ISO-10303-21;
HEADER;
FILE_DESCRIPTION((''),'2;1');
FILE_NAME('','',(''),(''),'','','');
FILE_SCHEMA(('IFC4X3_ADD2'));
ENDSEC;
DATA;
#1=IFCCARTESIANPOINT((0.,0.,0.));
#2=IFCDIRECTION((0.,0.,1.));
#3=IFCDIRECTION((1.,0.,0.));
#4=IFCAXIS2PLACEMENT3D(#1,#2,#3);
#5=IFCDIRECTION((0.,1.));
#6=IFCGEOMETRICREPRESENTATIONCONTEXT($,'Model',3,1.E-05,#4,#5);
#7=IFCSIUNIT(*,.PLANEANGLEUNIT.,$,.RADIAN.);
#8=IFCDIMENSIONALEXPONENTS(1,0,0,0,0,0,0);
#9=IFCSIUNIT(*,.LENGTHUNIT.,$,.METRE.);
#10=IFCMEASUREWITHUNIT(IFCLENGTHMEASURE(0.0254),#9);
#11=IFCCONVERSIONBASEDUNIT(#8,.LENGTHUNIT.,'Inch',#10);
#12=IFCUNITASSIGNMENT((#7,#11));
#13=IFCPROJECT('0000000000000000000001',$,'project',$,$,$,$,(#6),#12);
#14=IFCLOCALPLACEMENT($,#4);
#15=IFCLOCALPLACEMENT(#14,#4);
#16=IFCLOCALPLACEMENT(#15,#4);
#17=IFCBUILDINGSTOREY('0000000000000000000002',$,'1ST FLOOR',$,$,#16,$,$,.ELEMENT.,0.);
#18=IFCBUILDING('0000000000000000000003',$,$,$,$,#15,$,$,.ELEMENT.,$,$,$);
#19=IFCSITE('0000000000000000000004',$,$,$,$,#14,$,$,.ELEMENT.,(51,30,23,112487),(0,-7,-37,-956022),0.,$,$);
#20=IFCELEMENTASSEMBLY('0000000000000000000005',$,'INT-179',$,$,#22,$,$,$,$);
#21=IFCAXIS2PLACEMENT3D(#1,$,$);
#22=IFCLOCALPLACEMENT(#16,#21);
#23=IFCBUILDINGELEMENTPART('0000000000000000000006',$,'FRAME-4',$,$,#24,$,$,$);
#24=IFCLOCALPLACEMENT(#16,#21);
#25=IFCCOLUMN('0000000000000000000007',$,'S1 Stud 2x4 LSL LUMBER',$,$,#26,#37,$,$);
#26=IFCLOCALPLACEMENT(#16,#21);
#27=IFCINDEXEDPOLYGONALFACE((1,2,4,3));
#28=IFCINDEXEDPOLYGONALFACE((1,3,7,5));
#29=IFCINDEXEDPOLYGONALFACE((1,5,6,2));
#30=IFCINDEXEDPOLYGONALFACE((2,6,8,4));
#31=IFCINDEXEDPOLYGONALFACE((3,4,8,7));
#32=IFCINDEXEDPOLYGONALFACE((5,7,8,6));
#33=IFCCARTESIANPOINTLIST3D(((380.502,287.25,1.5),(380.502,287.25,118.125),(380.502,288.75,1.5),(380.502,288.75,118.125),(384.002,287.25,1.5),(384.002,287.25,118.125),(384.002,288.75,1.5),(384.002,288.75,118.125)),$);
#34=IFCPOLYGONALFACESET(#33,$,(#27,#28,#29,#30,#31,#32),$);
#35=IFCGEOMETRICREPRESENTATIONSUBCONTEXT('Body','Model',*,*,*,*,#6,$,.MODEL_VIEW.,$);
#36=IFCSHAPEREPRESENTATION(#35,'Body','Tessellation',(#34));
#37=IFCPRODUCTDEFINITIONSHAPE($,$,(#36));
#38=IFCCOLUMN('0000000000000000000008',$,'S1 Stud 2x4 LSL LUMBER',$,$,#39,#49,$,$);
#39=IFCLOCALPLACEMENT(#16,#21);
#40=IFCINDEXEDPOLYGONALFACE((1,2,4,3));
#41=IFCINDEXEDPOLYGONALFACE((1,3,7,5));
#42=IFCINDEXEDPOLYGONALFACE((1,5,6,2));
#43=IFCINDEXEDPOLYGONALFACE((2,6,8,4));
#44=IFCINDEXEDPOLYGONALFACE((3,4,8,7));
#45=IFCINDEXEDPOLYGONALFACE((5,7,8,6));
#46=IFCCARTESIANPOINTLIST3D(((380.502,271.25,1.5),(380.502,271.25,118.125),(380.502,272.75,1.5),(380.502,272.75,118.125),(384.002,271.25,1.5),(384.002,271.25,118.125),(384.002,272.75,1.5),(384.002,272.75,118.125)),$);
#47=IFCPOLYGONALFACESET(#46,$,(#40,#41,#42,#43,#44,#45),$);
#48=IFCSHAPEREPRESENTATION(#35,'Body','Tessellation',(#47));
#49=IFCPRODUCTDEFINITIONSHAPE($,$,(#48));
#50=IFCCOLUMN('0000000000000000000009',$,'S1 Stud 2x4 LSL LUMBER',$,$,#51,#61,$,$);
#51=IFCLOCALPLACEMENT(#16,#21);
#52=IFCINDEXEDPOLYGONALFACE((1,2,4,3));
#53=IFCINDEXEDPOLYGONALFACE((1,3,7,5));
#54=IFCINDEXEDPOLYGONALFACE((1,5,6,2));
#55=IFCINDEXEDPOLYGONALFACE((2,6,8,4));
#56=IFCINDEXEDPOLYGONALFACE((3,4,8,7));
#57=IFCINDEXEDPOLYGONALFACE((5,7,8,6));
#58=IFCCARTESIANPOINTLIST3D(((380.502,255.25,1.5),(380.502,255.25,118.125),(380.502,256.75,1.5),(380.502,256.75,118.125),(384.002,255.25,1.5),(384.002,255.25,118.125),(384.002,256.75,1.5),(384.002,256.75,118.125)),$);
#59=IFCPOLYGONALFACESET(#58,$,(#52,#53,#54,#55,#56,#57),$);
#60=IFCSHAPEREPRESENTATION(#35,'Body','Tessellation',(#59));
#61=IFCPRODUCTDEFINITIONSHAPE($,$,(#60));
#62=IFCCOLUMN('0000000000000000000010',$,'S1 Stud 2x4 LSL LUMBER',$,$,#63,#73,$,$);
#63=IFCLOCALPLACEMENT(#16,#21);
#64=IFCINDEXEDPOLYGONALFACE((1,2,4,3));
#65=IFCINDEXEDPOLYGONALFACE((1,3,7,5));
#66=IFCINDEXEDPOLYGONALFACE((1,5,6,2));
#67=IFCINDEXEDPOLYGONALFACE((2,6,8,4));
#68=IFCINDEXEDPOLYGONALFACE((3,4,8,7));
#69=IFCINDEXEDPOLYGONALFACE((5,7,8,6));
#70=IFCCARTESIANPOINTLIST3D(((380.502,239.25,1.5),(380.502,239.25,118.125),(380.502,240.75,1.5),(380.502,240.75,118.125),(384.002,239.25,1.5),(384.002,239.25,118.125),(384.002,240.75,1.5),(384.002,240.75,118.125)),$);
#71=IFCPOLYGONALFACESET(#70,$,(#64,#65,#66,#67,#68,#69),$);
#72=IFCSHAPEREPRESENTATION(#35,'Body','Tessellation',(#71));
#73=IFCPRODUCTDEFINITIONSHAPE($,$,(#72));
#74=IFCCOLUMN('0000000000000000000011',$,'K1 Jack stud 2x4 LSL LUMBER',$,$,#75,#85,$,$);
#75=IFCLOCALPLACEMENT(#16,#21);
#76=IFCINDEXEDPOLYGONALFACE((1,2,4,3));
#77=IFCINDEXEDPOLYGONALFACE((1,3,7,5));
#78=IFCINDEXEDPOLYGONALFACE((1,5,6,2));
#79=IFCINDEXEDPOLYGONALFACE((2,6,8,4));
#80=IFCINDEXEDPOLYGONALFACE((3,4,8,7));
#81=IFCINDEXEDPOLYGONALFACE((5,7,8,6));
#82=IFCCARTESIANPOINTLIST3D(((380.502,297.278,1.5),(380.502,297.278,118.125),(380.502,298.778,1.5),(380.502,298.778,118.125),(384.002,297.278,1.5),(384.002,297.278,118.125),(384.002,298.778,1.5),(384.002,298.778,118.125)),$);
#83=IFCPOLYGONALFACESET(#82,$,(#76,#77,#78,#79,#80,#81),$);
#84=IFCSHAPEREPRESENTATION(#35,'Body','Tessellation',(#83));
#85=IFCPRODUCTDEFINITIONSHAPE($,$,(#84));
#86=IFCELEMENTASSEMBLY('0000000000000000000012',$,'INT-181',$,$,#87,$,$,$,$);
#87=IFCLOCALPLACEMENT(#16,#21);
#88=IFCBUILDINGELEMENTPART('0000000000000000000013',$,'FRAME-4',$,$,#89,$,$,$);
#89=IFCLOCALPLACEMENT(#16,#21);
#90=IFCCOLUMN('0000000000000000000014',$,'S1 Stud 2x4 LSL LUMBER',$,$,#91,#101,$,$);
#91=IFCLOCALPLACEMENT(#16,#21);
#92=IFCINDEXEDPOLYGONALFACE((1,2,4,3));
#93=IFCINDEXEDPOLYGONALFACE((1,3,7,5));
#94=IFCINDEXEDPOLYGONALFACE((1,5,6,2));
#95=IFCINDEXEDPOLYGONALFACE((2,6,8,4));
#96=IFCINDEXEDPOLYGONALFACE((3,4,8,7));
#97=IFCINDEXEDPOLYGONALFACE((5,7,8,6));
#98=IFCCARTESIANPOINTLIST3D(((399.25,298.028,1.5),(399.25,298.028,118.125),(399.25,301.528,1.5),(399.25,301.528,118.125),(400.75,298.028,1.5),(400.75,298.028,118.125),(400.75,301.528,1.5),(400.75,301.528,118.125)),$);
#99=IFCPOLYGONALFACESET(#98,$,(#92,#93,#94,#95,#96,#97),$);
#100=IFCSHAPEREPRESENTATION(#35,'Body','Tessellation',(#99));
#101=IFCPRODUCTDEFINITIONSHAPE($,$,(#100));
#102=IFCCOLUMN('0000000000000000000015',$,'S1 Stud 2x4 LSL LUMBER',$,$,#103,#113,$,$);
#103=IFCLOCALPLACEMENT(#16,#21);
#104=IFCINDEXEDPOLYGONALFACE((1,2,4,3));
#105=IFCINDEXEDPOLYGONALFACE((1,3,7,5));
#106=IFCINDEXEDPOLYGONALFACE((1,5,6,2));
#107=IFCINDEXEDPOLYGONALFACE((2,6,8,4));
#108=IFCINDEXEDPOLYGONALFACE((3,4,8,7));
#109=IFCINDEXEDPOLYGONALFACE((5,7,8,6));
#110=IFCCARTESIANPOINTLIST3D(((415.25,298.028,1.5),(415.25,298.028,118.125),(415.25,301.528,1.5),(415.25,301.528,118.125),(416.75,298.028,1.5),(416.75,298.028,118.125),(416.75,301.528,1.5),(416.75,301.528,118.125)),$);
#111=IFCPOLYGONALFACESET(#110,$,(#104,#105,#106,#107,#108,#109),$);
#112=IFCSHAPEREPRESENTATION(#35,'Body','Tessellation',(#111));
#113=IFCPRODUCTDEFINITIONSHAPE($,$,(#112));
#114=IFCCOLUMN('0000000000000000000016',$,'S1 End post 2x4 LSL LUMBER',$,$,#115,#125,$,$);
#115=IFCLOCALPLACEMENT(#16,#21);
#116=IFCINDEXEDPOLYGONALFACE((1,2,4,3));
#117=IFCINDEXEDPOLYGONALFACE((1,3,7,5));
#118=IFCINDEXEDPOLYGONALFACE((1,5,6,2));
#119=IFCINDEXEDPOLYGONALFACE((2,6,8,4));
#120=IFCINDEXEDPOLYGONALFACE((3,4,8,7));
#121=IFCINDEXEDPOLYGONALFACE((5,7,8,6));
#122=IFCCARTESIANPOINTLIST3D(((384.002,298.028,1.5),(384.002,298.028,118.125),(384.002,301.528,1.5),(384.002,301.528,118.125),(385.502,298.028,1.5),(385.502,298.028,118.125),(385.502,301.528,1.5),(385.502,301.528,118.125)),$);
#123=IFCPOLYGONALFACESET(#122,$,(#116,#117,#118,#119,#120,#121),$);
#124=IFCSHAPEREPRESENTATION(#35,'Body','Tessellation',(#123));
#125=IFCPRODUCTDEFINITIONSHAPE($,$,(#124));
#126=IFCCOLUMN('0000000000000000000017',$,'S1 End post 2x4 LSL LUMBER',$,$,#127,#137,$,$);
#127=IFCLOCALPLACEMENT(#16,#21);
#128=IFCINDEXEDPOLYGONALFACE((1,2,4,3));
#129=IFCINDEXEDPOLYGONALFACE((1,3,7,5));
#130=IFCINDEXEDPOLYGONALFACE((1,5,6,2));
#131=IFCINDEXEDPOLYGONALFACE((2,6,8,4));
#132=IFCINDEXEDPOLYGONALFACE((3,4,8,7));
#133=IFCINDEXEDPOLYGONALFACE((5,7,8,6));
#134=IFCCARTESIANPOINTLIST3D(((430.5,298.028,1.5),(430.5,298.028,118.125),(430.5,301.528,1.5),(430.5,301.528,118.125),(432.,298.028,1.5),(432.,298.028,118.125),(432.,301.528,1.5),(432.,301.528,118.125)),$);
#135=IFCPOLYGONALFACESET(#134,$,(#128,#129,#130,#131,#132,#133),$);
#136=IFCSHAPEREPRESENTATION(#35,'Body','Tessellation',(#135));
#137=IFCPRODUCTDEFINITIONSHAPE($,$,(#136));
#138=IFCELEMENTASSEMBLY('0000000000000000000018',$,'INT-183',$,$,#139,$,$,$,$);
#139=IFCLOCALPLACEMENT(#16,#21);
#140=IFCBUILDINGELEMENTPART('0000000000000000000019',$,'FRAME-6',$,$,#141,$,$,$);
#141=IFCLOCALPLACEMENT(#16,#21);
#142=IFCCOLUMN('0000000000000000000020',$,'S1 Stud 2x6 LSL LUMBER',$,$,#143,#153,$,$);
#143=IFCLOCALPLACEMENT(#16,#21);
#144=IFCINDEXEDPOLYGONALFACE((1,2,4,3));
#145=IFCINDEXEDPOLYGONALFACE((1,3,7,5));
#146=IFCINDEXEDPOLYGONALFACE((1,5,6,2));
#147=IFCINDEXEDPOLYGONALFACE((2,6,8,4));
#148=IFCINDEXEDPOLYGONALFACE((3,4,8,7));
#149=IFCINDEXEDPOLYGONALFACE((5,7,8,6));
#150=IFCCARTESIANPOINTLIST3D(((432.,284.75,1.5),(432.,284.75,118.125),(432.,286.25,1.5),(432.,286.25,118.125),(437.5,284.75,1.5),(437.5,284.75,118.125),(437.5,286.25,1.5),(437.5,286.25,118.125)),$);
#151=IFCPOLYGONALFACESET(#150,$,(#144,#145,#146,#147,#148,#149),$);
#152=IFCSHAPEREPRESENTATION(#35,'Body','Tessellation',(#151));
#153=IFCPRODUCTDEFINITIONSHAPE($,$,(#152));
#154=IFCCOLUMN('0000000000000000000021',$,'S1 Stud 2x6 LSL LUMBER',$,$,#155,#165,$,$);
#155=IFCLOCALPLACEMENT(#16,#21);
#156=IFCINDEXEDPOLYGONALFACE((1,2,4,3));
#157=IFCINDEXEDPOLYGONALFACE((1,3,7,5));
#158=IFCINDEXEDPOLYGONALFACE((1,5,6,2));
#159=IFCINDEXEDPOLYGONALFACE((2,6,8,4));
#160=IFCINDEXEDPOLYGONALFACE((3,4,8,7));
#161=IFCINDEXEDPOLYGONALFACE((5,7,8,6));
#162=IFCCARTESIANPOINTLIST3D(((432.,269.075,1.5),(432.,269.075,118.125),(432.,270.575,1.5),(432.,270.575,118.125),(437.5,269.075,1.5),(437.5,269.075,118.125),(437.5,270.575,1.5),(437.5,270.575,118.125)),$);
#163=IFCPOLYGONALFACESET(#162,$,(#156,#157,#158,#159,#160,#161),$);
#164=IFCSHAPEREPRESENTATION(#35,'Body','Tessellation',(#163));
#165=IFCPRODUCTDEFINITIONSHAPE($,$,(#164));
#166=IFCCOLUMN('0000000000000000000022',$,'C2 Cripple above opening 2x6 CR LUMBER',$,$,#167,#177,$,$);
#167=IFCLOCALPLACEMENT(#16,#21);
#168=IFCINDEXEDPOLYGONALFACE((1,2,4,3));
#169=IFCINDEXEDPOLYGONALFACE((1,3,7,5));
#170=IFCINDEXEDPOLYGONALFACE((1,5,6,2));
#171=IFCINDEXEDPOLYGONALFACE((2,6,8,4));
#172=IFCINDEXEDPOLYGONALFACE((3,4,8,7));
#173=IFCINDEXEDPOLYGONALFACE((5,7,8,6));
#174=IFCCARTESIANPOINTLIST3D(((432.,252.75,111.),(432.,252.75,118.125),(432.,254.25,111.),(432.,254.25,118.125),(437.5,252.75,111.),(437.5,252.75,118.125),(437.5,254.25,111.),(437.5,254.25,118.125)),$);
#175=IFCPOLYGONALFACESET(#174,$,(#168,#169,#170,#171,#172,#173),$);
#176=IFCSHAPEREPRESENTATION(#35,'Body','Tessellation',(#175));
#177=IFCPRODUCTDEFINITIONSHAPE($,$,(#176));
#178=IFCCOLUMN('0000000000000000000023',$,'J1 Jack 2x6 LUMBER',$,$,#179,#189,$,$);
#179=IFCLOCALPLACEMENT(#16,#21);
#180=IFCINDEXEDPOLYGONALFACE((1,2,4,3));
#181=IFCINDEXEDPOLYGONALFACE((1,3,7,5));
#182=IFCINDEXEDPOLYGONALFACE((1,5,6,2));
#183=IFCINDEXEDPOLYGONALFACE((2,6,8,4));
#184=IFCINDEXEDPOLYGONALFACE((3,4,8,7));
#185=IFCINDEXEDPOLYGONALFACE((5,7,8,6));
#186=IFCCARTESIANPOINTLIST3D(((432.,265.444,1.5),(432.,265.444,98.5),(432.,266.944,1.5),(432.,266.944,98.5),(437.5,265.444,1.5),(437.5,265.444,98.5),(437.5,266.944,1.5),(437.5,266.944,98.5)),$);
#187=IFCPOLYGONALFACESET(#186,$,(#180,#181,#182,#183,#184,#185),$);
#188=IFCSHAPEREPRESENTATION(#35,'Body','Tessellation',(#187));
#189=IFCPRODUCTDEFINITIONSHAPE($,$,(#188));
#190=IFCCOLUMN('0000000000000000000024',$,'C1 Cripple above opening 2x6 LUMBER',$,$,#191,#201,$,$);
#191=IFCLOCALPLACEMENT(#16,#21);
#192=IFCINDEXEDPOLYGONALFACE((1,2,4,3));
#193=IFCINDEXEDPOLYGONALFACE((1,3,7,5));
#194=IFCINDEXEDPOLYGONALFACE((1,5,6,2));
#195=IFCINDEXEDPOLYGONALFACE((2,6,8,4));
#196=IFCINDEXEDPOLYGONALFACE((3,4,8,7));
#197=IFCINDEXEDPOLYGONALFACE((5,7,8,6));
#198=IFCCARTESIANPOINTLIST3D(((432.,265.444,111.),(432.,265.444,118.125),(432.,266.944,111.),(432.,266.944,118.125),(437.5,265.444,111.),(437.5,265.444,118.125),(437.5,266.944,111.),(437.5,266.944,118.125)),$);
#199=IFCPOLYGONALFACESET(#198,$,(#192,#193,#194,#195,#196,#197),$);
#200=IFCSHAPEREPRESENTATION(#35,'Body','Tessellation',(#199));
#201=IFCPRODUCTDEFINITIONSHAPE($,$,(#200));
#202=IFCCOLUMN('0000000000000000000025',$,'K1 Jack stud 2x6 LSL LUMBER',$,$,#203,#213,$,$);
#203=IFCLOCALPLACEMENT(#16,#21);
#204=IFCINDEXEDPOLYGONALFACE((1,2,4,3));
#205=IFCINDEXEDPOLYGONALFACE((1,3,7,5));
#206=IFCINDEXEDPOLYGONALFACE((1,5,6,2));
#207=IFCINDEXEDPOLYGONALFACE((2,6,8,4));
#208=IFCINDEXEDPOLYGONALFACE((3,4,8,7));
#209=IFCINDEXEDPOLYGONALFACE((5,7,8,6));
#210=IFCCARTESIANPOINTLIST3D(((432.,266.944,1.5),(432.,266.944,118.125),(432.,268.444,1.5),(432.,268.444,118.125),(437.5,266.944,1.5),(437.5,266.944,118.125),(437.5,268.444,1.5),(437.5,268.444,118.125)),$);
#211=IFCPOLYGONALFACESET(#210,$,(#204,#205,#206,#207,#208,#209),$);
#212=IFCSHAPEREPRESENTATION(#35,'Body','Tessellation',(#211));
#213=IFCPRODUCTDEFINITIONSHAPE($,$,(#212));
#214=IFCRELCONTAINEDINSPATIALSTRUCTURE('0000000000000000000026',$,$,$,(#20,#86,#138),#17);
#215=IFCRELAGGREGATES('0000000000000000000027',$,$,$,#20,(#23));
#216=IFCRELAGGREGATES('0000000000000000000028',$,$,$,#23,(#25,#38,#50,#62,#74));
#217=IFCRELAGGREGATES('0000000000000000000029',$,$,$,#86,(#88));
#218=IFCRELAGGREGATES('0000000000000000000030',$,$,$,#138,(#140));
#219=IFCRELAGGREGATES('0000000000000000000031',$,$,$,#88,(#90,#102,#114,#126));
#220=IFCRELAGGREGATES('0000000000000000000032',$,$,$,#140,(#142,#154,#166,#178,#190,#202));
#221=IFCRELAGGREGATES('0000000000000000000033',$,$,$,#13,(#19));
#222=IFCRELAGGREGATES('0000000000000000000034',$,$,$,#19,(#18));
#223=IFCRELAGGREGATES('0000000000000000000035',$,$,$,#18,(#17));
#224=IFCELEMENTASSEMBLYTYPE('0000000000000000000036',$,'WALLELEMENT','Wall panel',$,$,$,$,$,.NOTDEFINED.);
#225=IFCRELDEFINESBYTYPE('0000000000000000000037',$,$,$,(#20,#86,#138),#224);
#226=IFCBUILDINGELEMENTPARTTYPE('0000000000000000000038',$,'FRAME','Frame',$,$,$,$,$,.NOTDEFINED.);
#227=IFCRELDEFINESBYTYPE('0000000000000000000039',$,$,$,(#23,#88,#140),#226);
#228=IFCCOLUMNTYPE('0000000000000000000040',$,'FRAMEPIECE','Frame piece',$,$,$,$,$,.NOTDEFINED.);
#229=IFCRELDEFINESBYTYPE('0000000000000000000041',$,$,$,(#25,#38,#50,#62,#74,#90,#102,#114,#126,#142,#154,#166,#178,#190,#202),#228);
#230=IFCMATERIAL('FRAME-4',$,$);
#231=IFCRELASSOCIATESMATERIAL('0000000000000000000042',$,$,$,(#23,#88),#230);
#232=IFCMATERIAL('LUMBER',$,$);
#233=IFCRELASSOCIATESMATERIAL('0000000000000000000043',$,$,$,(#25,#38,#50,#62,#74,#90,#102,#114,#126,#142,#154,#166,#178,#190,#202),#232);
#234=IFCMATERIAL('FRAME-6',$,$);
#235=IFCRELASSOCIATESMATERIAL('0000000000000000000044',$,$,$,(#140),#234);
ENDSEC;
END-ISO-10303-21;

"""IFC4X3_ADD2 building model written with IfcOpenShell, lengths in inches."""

from ifc_helpers import new_model, entity, si_unit, converted_unit, direction, frame, origin_with_axes, origin_2d_with_axis, place, context, subcontext, project, spatial, rectangle, extrude, material, type_object, element, aggregate, save


model = new_model("IFC4X3_ADD2")

# Units and contexts
model_context = context("Model", 3, precision=1e-05, world=origin_with_axes(), true_north=direction((0.0, 1.0)))
body_context = subcontext(model_context, "Body", "Model", "MODEL_VIEW")
ifc_project = project(units=[si_unit("PLANEANGLEUNIT", "RADIAN"), converted_unit("LENGTHUNIT", "Inch", entity("IfcLengthMeasure", 0.0254), si_unit("LENGTHUNIT", "METRE"), dimensions=[1, 0, 0, 0, 0, 0, 0])], contexts=[model_context])

# Site, building, storey
site_placement = place(None, origin_with_axes())
site = spatial("IfcSite", under=ifc_project, at=site_placement, CompositionType="ELEMENT", RefLatitude=(51, 30, 23, 112487), RefLongitude=(0, -7, -37, -956022), RefElevation=0.0)
building_placement = place(site_placement, origin_with_axes())
building = spatial("IfcBuilding", under=site, at=building_placement, CompositionType="ELEMENT")
storey_placement = place(building_placement, origin_with_axes())
storey = spatial("IfcBuildingStorey", under=building, at=storey_placement, Name="1ST FLOOR", CompositionType="ELEMENT", Elevation=0.0)

# Element assemblies, building element parts, columns
element_assembly_type_1 = type_object("IfcElementAssemblyType", Name="WALLELEMENT", Description="Wall panel", PredefinedType="NOTDEFINED")
assembly_1_placement = place(storey_placement, origin_with_axes())
assembly_1 = element("IfcElementAssembly", 1, at=assembly_1_placement, inside=storey, type_object=element_assembly_type_1, Name="INT-179")
ifc_material_1 = material(Name="FRAME-4")
building_element_part_type = type_object("IfcBuildingElementPartType", Name="FRAME", Description="Frame", PredefinedType="NOTDEFINED")
building_element_part_1_placement = place(storey_placement, origin_with_axes())
building_element_part_1 = element("IfcBuildingElementPart", 2, at=building_element_part_1_placement, type_object=building_element_part_type, material=ifc_material_1, Name="FRAME-4")
aggregate(assembly_1, [building_element_part_1])
ifc_material_2 = material(Name="LUMBER")
column_type = type_object("IfcColumnType", Name="FRAMEPIECE", Description="Frame piece", PredefinedType="NOTDEFINED")
column_1_placement = place(storey_placement, frame((382.252, 288.0, 118.125), z_axis=(0.0, 0.0, -1.0), x_axis=(0.0, 1.0, 0.0)))
column_1 = element("IfcColumn", 3, at=column_1_placement, type_object=column_type, material=ifc_material_2, Name="S1 Stud 2x4 LSL LUMBER", context=body_context, shape_type="SweptSolid", body=[
    extrude(rectangle(XDim=1.5, YDim=3.5, at=origin_2d_with_axis()), origin_with_axes(), (0.0, 0.0, 1.0), 116.625),
])
column_2_placement = place(storey_placement, frame((382.252, 272.0, 118.125), z_axis=(0.0, 0.0, -1.0), x_axis=(0.0, 1.0, 0.0)))
column_2 = element("IfcColumn", 4, at=column_2_placement, type_object=column_type, material=ifc_material_2, Name="S1 Stud 2x4 LSL LUMBER", context=body_context, shape_type="SweptSolid", body=[
    extrude(rectangle(XDim=1.5, YDim=3.5, at=origin_2d_with_axis()), origin_with_axes(), (0.0, 0.0, 1.0), 116.625),
])
column_3_placement = place(storey_placement, frame((382.252, 256.0, 118.125), z_axis=(0.0, 0.0, -1.0), x_axis=(0.0, 1.0, 0.0)))
column_3 = element("IfcColumn", 5, at=column_3_placement, type_object=column_type, material=ifc_material_2, Name="S1 Stud 2x4 LSL LUMBER", context=body_context, shape_type="SweptSolid", body=[
    extrude(rectangle(XDim=1.5, YDim=3.5, at=origin_2d_with_axis()), origin_with_axes(), (0.0, 0.0, 1.0), 116.625),
])
column_4_placement = place(storey_placement, frame((382.252, 240.0, 118.125), z_axis=(0.0, 0.0, -1.0), x_axis=(0.0, 1.0, 0.0)))
column_4 = element("IfcColumn", 6, at=column_4_placement, type_object=column_type, material=ifc_material_2, Name="S1 Stud 2x4 LSL LUMBER", context=body_context, shape_type="SweptSolid", body=[
    extrude(rectangle(XDim=1.5, YDim=3.5, at=origin_2d_with_axis()), origin_with_axes(), (0.0, 0.0, 1.0), 116.625),
])
column_5_placement = place(storey_placement, frame((382.252, 298.028, 118.125), z_axis=(0.0, 0.0, -1.0), x_axis=(0.0, -1.0, 0.0)))
column_5 = element("IfcColumn", 7, at=column_5_placement, type_object=column_type, material=ifc_material_2, Name="K1 Jack stud 2x4 LSL LUMBER", context=body_context, shape_type="SweptSolid", body=[
    extrude(rectangle(XDim=1.5, YDim=3.5, at=origin_2d_with_axis()), origin_with_axes(), (0.0, 0.0, 1.0), 116.625),
])
aggregate(building_element_part_1, [column_1, column_2, column_3, column_4, column_5])
assembly_2_placement = place(storey_placement, origin_with_axes())
assembly_2 = element("IfcElementAssembly", 8, at=assembly_2_placement, inside=storey, type_object=element_assembly_type_1, Name="INT-181")
building_element_part_2_placement = place(storey_placement, origin_with_axes())
building_element_part_2 = element("IfcBuildingElementPart", 9, at=building_element_part_2_placement, type_object=building_element_part_type, material=ifc_material_1, Name="FRAME-4")
aggregate(assembly_2, [building_element_part_2])
column_6_placement = place(storey_placement, frame((400.0, 299.778, 118.125), z_axis=(0.0, 0.0, -1.0), x_axis=(-1.0, 0.0, 0.0)))
column_6 = element("IfcColumn", 10, at=column_6_placement, type_object=column_type, material=ifc_material_2, Name="S1 Stud 2x4 LSL LUMBER", context=body_context, shape_type="SweptSolid", body=[
    extrude(rectangle(XDim=1.5, YDim=3.5, at=origin_2d_with_axis()), origin_with_axes(), (0.0, 0.0, 1.0), 116.625),
])
column_7_placement = place(storey_placement, frame((416.0, 299.778, 118.125), z_axis=(0.0, 0.0, -1.0), x_axis=(-1.0, 0.0, 0.0)))
column_7 = element("IfcColumn", 11, at=column_7_placement, type_object=column_type, material=ifc_material_2, Name="S1 Stud 2x4 LSL LUMBER", context=body_context, shape_type="SweptSolid", body=[
    extrude(rectangle(XDim=1.5, YDim=3.5, at=origin_2d_with_axis()), origin_with_axes(), (0.0, 0.0, 1.0), 116.625),
])
column_8_placement = place(storey_placement, frame((384.752, 299.778, 1.5), z_axis=(0.0, 0.0, 1.0), x_axis=(1.0, 0.0, 0.0)))
column_8 = element("IfcColumn", 12, at=column_8_placement, type_object=column_type, material=ifc_material_2, Name="S1 End post 2x4 LSL LUMBER", context=body_context, shape_type="SweptSolid", body=[
    extrude(rectangle(XDim=1.5, YDim=3.5, at=origin_2d_with_axis()), origin_with_axes(), (0.0, 0.0, 1.0), 116.625),
])
column_9_placement = place(storey_placement, frame((431.25, 299.778, 118.125), z_axis=(0.0, 0.0, -1.0), x_axis=(-1.0, 0.0, 0.0)))
column_9 = element("IfcColumn", 13, at=column_9_placement, type_object=column_type, material=ifc_material_2, Name="S1 End post 2x4 LSL LUMBER", context=body_context, shape_type="SweptSolid", body=[
    extrude(rectangle(XDim=1.5, YDim=3.5, at=origin_2d_with_axis()), origin_with_axes(), (0.0, 0.0, 1.0), 116.625),
])
assembly_3_placement = place(storey_placement, origin_with_axes())
assembly_3 = element("IfcElementAssembly", 14, at=assembly_3_placement, inside=storey, type_object=element_assembly_type_1, Name="INT-183")
ifc_material_3 = material(Name="FRAME-6")
building_element_part_3_placement = place(storey_placement, origin_with_axes())
building_element_part_3 = element("IfcBuildingElementPart", 15, at=building_element_part_3_placement, type_object=building_element_part_type, material=ifc_material_3, Name="FRAME-6")
aggregate(assembly_3, [building_element_part_3])
column_10_placement = place(storey_placement, frame((434.75, 285.5, 118.125), z_axis=(0.0, 0.0, -1.0), x_axis=(0.0, 1.0, 0.0)))
column_10 = element("IfcColumn", 16, at=column_10_placement, type_object=column_type, material=ifc_material_2, Name="S1 Stud 2x6 LSL LUMBER", context=body_context, shape_type="SweptSolid", body=[
    extrude(rectangle(XDim=1.5, YDim=5.5, at=origin_2d_with_axis()), origin_with_axes(), (0.0, 0.0, 1.0), 116.625),
])
column_11_placement = place(storey_placement, frame((434.75, 269.825, 118.125), z_axis=(0.0, 0.0, -1.0), x_axis=(0.0, 1.0, 0.0)))
column_11 = element("IfcColumn", 17, at=column_11_placement, type_object=column_type, material=ifc_material_2, Name="S1 Stud 2x6 LSL LUMBER", context=body_context, shape_type="SweptSolid", body=[
    extrude(rectangle(XDim=1.5, YDim=5.5, at=origin_2d_with_axis()), origin_with_axes(), (0.0, 0.0, 1.0), 116.625),
])
column_12_placement = place(storey_placement, frame((434.75, 253.5, 118.125), z_axis=(0.0, 0.0, -1.0), x_axis=(0.0, 1.0, 0.0)))
column_12 = element("IfcColumn", 18, at=column_12_placement, type_object=column_type, material=ifc_material_2, Name="C2 Cripple above opening 2x6 CR LUMBER", context=body_context, shape_type="SweptSolid", body=[
    extrude(rectangle(XDim=1.5, YDim=5.5, at=origin_2d_with_axis()), origin_with_axes(), (0.0, 0.0, 1.0), 7.125),
])
column_13_placement = place(storey_placement, frame((434.75, 266.194, 1.5), z_axis=(0.0, 0.0, 1.0), x_axis=(0.0, -1.0, 0.0)))
column_13 = element("IfcColumn", 19, at=column_13_placement, type_object=column_type, material=ifc_material_2, Name="J1 Jack 2x6 LUMBER", context=body_context, shape_type="SweptSolid", body=[
    extrude(rectangle(XDim=1.5, YDim=5.5, at=origin_2d_with_axis()), origin_with_axes(), (0.0, 0.0, 1.0), 97.0),
])
column_14_placement = place(storey_placement, frame((434.75, 266.194, 111.0), z_axis=(0.0, 0.0, 1.0), x_axis=(0.0, -1.0, 0.0)))
column_14 = element("IfcColumn", 20, at=column_14_placement, type_object=column_type, material=ifc_material_2, Name="C1 Cripple above opening 2x6 LUMBER", context=body_context, shape_type="SweptSolid", body=[
    extrude(rectangle(XDim=1.5, YDim=5.5, at=origin_2d_with_axis()), origin_with_axes(), (0.0, 0.0, 1.0), 7.125),
])
column_15_placement = place(storey_placement, frame((434.75, 267.694, 1.5), z_axis=(0.0, 0.0, 1.0), x_axis=(0.0, -1.0, 0.0)))
column_15 = element("IfcColumn", 21, at=column_15_placement, type_object=column_type, material=ifc_material_2, Name="K1 Jack stud 2x6 LSL LUMBER", context=body_context, shape_type="SweptSolid", body=[
    extrude(rectangle(XDim=1.5, YDim=5.5, at=origin_2d_with_axis()), origin_with_axes(), (0.0, 0.0, 1.0), 116.625),
])

aggregate(building_element_part_2, [column_6, column_7, column_8, column_9])
aggregate(building_element_part_3, [column_10, column_11, column_12, column_13, column_14, column_15])

save(model, "model.ifc")
